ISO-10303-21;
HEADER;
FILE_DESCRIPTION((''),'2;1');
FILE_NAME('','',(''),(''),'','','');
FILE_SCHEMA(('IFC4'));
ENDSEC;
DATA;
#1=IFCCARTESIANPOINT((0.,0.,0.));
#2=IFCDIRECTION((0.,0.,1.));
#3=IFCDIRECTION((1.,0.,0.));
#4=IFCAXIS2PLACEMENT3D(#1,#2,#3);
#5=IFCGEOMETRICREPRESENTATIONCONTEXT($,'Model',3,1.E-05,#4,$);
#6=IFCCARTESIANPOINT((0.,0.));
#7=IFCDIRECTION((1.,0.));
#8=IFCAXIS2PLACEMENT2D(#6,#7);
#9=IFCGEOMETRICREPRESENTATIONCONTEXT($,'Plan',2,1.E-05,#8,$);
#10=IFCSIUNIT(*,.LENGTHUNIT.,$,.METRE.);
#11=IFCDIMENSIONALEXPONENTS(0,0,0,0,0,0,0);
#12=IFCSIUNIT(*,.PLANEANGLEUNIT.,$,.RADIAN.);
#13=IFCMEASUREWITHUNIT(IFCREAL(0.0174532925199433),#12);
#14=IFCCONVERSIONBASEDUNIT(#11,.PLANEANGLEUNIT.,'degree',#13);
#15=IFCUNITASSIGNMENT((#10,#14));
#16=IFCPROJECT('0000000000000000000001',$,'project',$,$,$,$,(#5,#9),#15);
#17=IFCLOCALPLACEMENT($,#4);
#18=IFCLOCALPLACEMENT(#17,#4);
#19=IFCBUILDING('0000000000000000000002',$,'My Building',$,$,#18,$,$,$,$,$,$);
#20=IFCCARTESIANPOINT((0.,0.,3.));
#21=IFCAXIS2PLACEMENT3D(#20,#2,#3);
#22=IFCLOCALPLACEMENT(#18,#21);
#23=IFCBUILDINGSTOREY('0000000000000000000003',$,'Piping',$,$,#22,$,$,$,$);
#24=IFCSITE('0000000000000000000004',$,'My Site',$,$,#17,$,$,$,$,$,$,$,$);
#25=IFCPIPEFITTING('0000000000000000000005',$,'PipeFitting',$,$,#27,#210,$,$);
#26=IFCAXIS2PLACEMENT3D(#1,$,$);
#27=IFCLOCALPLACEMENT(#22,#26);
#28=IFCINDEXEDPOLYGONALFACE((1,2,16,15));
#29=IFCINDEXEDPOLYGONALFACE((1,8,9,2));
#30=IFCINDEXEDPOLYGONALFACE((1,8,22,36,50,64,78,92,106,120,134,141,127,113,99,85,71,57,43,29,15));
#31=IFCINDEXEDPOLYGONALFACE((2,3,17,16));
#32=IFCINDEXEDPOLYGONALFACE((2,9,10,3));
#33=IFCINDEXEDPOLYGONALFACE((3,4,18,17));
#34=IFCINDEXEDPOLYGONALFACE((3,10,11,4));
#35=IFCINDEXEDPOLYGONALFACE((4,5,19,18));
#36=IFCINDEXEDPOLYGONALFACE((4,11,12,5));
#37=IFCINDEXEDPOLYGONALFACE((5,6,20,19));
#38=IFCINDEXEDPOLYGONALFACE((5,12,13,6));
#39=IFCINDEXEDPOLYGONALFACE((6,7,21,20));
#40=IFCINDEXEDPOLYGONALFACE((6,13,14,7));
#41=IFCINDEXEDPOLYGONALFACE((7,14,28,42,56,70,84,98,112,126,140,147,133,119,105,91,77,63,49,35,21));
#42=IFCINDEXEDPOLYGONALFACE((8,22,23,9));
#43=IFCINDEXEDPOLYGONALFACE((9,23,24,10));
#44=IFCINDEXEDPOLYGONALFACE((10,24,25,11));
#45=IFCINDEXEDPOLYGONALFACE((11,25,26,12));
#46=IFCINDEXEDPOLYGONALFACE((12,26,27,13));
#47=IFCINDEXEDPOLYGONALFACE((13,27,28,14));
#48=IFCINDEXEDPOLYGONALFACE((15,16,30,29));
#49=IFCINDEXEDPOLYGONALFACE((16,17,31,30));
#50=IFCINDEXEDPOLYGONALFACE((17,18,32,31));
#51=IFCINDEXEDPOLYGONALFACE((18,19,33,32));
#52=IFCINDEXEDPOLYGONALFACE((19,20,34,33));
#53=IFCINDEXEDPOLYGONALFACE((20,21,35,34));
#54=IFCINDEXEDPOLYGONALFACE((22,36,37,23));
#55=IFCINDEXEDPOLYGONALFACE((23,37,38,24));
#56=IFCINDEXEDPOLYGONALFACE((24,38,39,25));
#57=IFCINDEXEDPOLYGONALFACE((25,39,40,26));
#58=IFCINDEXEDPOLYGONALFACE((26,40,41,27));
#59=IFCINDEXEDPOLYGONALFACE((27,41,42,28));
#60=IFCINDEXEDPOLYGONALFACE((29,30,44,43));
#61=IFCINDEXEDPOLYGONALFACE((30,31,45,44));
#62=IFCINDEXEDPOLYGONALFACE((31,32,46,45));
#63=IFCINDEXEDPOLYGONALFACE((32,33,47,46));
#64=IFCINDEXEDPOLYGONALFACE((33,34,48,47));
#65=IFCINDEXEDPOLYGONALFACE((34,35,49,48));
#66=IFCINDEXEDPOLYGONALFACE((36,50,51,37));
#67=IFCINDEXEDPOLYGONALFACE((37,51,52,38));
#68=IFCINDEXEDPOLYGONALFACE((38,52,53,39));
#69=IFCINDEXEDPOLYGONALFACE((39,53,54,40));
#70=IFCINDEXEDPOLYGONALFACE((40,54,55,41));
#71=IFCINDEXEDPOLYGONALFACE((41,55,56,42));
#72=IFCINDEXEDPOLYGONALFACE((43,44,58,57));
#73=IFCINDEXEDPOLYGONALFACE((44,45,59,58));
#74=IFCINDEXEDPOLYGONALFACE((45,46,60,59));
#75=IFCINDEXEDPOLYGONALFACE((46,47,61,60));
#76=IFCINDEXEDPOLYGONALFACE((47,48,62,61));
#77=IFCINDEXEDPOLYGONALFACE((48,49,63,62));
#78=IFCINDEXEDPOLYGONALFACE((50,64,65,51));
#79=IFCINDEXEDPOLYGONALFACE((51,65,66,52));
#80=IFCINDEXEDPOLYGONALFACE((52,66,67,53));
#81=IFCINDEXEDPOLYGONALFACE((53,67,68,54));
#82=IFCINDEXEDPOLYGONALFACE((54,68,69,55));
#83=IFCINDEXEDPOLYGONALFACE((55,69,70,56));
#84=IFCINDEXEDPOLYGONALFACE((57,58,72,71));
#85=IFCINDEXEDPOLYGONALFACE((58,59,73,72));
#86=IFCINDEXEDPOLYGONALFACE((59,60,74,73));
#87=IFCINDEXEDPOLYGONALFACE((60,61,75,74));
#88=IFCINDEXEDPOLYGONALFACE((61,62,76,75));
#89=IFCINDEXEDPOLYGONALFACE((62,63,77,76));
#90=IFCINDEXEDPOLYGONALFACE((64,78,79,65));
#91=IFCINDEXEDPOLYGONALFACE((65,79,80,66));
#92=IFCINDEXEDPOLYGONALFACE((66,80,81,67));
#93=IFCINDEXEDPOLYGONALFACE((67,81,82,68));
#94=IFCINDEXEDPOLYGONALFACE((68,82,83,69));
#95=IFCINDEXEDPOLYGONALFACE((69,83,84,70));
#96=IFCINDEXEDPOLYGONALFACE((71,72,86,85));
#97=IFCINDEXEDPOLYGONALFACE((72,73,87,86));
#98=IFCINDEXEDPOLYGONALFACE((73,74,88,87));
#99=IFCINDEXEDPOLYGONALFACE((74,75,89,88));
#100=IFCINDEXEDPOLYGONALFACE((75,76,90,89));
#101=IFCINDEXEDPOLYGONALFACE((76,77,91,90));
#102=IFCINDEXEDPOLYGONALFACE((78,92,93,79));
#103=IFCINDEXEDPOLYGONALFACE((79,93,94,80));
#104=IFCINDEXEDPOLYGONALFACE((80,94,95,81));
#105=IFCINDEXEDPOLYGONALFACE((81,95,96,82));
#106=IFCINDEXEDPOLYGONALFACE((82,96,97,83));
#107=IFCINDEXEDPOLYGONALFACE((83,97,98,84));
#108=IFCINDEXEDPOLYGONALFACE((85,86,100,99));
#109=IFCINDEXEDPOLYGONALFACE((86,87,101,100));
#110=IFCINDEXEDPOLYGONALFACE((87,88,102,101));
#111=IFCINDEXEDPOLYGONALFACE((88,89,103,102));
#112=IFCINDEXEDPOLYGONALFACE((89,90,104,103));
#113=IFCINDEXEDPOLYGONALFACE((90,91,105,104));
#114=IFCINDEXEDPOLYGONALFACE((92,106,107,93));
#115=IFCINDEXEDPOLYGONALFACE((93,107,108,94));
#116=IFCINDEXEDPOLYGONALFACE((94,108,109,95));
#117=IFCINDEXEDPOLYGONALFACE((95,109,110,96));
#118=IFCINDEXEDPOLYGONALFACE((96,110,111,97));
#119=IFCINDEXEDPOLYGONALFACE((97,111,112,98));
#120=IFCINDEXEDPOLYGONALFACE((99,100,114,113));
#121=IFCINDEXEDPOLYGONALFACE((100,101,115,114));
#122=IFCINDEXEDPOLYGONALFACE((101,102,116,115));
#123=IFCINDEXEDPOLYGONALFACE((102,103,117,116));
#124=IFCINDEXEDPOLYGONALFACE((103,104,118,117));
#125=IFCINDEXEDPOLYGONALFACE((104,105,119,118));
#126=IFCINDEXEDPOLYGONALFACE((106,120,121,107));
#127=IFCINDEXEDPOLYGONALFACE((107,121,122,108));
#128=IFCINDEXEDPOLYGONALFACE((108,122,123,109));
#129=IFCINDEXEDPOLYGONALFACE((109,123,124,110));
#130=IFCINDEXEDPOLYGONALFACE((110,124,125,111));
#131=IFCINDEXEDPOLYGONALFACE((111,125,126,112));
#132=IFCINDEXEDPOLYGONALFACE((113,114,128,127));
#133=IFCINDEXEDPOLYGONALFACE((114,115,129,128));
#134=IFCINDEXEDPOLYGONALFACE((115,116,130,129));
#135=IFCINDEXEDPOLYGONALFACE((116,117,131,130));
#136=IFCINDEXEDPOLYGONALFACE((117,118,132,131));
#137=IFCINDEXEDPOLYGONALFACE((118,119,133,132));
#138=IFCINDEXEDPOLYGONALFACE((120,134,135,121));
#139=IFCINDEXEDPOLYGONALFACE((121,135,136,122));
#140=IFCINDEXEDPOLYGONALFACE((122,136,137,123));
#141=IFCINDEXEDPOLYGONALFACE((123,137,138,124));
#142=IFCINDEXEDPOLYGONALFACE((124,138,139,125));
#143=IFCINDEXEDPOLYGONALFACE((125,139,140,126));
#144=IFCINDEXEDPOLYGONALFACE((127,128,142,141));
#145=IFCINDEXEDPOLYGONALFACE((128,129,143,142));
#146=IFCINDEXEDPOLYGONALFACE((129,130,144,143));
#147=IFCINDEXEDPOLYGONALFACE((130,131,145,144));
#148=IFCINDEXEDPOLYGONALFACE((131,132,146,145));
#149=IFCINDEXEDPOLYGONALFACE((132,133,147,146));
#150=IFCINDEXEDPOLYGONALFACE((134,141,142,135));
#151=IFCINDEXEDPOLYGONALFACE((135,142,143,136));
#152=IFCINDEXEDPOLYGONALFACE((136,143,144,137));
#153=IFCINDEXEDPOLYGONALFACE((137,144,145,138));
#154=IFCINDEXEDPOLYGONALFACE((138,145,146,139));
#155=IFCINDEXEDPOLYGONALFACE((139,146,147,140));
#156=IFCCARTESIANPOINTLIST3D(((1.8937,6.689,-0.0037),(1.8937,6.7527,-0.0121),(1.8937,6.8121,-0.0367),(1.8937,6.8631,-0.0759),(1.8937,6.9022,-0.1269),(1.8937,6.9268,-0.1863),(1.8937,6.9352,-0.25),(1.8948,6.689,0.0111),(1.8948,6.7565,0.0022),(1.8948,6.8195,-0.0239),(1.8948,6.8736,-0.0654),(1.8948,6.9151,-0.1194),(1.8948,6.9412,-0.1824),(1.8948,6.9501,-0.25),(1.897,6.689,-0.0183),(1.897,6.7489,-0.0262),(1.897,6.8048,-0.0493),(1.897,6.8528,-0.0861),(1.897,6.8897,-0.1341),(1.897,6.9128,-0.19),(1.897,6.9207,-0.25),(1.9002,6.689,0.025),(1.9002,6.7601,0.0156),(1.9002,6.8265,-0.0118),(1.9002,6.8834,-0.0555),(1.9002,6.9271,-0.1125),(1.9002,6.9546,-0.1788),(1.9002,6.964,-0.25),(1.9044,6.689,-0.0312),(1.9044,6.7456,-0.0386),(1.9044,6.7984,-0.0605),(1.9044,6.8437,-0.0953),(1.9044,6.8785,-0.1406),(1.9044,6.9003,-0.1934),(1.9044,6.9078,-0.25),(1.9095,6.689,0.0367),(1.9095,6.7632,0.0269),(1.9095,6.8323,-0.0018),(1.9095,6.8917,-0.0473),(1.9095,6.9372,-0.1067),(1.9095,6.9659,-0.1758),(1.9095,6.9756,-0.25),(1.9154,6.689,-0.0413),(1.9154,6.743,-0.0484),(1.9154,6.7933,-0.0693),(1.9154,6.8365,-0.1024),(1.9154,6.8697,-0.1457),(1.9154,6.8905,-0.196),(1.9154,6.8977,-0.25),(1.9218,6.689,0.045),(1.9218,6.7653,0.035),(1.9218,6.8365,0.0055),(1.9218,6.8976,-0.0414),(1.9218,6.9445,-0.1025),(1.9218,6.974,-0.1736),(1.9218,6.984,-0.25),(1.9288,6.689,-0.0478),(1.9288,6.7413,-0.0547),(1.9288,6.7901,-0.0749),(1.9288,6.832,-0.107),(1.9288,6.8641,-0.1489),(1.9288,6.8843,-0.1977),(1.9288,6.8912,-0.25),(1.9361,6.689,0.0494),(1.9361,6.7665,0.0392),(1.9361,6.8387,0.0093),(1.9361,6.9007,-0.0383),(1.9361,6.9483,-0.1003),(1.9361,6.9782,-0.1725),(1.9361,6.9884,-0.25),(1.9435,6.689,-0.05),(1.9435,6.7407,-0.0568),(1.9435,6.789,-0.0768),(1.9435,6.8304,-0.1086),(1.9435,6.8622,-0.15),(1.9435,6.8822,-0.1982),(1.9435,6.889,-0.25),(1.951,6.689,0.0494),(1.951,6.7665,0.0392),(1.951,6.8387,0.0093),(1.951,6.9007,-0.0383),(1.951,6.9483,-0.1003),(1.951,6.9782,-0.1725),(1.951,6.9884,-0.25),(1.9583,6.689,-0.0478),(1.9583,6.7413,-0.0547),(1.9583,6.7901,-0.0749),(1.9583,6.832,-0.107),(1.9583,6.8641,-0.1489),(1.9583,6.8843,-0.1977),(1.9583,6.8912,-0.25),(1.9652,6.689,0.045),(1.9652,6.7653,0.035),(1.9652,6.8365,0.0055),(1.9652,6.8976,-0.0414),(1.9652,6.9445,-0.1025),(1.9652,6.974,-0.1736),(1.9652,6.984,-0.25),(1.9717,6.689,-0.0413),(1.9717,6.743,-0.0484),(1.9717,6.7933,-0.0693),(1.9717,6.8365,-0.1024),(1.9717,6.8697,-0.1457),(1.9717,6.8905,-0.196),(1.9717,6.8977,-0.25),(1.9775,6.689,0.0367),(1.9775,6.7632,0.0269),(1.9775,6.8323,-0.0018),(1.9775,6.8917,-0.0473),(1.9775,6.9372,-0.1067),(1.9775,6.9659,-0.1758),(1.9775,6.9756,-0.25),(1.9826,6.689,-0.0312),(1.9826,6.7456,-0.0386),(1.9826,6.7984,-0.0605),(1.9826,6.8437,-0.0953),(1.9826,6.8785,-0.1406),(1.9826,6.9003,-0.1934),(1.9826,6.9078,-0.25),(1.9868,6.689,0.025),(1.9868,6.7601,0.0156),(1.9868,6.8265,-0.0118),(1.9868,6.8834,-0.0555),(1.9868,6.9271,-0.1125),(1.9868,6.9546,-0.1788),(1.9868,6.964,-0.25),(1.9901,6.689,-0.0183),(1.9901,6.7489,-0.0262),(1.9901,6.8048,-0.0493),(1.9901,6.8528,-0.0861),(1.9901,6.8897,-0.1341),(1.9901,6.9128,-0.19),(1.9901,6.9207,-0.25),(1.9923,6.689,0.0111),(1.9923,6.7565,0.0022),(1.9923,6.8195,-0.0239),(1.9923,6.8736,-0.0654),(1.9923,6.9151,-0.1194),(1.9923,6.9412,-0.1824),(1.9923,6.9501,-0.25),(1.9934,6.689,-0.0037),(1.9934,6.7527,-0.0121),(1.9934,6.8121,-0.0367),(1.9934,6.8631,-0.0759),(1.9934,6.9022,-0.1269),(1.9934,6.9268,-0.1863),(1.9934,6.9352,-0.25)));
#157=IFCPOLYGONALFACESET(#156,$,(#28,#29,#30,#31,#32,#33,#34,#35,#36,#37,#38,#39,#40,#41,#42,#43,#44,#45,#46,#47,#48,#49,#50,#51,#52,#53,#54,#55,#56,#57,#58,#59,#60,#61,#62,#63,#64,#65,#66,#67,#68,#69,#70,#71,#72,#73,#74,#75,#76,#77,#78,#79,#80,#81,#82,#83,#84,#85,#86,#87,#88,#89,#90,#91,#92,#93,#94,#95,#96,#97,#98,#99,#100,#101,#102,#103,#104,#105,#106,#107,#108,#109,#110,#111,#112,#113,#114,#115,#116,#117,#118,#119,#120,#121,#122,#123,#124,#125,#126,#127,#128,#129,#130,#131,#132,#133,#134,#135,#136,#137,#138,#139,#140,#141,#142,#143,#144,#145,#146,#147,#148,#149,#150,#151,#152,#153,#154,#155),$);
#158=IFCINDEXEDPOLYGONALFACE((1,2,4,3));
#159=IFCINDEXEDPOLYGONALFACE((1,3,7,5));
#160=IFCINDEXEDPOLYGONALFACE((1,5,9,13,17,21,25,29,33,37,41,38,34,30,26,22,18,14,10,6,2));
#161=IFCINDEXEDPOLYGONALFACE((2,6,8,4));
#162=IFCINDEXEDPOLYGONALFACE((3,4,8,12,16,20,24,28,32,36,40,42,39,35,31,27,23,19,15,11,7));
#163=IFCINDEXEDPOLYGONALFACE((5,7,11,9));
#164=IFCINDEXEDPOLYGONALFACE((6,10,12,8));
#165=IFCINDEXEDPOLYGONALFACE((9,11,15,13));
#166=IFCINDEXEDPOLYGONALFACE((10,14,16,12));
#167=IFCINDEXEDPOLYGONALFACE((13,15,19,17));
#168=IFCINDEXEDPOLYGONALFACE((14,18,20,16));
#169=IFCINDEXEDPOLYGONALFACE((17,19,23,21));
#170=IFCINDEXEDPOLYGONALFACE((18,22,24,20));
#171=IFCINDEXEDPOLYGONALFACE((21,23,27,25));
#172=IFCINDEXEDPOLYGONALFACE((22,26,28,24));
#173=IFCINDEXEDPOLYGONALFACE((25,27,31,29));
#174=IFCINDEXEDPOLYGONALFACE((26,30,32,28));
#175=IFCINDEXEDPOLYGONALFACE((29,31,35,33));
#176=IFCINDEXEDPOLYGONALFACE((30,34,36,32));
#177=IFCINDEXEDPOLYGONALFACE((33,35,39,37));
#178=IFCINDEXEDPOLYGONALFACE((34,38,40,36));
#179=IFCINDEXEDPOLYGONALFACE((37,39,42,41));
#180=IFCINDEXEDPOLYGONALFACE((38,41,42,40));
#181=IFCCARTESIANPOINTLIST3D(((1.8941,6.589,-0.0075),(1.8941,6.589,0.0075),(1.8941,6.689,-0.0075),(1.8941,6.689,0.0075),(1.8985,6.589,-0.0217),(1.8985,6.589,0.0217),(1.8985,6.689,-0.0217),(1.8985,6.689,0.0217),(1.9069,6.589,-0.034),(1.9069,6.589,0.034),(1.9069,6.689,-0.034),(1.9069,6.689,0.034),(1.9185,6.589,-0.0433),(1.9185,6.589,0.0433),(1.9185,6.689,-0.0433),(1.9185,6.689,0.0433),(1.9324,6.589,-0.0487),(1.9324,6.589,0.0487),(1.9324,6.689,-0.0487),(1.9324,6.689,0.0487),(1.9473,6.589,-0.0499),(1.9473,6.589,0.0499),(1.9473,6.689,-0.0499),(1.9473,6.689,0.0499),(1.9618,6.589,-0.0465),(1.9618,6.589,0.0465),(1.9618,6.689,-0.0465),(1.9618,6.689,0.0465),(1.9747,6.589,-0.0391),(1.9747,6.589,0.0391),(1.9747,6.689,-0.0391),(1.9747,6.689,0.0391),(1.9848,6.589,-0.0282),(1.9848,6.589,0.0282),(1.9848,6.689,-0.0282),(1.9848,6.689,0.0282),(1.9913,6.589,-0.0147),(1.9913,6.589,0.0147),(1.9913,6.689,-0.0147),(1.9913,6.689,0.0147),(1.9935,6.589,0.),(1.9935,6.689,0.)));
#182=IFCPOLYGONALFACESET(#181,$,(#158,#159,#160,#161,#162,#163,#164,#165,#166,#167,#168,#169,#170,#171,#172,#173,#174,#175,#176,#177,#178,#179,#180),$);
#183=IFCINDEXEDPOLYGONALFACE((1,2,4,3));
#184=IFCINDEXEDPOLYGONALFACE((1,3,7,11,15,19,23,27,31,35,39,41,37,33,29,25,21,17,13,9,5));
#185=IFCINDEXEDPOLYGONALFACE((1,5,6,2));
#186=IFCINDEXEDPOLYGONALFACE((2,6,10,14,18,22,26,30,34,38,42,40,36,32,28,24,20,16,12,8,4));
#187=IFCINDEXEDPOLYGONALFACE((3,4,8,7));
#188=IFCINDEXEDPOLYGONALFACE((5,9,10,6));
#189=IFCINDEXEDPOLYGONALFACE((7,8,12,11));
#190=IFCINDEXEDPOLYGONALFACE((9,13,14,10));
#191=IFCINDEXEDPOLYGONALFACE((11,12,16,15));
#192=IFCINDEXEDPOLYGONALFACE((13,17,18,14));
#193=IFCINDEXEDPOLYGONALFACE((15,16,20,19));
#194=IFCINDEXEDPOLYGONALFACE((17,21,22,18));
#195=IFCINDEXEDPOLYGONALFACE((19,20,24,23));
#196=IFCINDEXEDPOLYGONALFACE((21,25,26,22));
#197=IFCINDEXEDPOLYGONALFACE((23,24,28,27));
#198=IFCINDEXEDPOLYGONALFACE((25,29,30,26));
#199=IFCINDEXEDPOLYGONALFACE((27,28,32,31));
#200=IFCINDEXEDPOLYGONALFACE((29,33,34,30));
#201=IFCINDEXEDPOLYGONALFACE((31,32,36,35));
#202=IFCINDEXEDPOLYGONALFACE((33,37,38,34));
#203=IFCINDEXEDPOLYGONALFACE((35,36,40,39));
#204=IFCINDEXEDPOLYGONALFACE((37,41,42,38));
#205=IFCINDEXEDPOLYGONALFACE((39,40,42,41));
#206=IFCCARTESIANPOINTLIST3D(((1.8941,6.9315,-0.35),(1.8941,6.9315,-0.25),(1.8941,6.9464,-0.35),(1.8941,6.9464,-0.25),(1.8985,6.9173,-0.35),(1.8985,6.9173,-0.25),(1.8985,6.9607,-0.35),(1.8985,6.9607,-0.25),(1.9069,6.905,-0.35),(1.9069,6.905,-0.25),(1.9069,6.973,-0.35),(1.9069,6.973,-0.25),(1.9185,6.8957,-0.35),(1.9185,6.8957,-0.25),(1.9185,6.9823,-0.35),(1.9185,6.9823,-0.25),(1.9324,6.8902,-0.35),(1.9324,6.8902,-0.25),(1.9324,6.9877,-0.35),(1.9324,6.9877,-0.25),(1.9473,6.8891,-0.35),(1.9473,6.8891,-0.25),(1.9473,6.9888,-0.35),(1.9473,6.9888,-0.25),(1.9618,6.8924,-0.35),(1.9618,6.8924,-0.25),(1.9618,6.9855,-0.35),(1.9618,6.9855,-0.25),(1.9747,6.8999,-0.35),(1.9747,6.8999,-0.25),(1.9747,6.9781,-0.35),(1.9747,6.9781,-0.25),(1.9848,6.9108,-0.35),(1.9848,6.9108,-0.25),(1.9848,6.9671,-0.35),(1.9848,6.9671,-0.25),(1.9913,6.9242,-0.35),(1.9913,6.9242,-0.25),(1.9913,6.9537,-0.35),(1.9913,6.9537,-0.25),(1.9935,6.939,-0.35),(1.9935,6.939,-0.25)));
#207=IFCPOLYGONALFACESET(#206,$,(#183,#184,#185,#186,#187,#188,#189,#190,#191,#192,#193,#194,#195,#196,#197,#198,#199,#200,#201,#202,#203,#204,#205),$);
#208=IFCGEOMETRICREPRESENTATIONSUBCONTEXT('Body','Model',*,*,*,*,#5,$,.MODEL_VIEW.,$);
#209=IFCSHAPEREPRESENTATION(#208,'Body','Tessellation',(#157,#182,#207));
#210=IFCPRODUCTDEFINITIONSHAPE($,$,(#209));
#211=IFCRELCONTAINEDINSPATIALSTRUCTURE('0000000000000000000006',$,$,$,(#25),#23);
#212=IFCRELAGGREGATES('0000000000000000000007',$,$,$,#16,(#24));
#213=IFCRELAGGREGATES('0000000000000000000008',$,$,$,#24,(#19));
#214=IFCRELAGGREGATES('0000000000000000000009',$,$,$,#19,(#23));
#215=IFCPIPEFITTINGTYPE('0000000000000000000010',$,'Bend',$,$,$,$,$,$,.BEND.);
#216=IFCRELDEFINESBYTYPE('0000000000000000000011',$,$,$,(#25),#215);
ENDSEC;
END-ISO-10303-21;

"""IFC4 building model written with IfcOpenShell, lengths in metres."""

from ifc_helpers import new_model, entity, si_unit, converted_unit, frame, origin_with_axes, origin_2d_with_axis, place, context, subcontext, project, spatial, circle, extrude, source, transform, mapped, type_object, type_shapes, element, save


model = new_model("IFC4")

# Units and contexts
model_context = context("Model", 3, precision=1e-05, world=origin_with_axes())
plan_context = context("Plan", 2, precision=1e-05, world=origin_2d_with_axis())
body_context = subcontext(model_context, "Body", "Model", "MODEL_VIEW")
ifc_project = project(units=[si_unit("LENGTHUNIT", "METRE"), converted_unit("PLANEANGLEUNIT", "degree", entity("IfcReal", 0.0174532925199433), si_unit("PLANEANGLEUNIT", "RADIAN"), dimensions=[0, 0, 0, 0, 0, 0, 0])], contexts=[model_context, plan_context])

# Site, building, storey
site_placement = place(None, origin_with_axes())
site = spatial("IfcSite", under=ifc_project, at=site_placement, Name="My Site")
building_placement = place(site_placement, origin_with_axes())
building = spatial("IfcBuilding", under=site, at=building_placement, Name="My Building")
storey_placement = place(building_placement, frame((0.0, 0.0, 3.0), z_axis=(0.0, 0.0, 1.0), x_axis=(1.0, 0.0, 0.0)))
storey = spatial("IfcBuildingStorey", under=building, at=storey_placement, Name="Piping")

# Pipe fitting
pipe_fitting_type_1 = type_object("IfcPipeFittingType", Name="Bend", PredefinedType="BEND")
shared_shape = source(origin_with_axes(), body_context, "Body", "SolidModel", [
    entity("IfcSweptDiskSolid", entity("IfcIndexedPolyCurve", entity("IfcCartesianPointList3D", [[0.0, 0.0, -0.1], [0.0, -0.0732, -0.2768], [0.0, -0.25, -0.35]]), [entity("IfcArcIndex", [1, 2, 3])]), 0.05),
    extrude(circle(Radius=0.05), origin_with_axes(), (0.0, 0.0, -1.0), 0.1),
    extrude(circle(Radius=0.05), frame((0.0, -0.25, -0.35), z_axis=(0.0, -1.0, 0.0), x_axis=(1.0, 0.0, 0.0)), (0.0, 0.0, 1.0), 0.1),
])
type_shapes(pipe_fitting_type_1, [shared_shape])
for number, where, z_axis, x_axis, name in (
    (1, (1.9435, 6.589, 0.0), (0.0, -1.0, 0.0), (1.0, 0.0, 0.0), "PipeFitting"),
):
    element("IfcPipeFitting", number, at=place(storey_placement, frame(where, z_axis=z_axis, x_axis=x_axis)), inside=storey, type_object=pipe_fitting_type_1, Name=name, context=body_context, shape_type="MappedRepresentation", body=[
        mapped(shared_shape, transform((0.0, 0.0, 0.0), x_axis=(1.0, 0.0, 0.0), y_axis=(0.0, 1.0, 0.0), z_axis=(0.0, 0.0, 1.0), scale=1.0)),
    ])

save(model, "model.ifc")
